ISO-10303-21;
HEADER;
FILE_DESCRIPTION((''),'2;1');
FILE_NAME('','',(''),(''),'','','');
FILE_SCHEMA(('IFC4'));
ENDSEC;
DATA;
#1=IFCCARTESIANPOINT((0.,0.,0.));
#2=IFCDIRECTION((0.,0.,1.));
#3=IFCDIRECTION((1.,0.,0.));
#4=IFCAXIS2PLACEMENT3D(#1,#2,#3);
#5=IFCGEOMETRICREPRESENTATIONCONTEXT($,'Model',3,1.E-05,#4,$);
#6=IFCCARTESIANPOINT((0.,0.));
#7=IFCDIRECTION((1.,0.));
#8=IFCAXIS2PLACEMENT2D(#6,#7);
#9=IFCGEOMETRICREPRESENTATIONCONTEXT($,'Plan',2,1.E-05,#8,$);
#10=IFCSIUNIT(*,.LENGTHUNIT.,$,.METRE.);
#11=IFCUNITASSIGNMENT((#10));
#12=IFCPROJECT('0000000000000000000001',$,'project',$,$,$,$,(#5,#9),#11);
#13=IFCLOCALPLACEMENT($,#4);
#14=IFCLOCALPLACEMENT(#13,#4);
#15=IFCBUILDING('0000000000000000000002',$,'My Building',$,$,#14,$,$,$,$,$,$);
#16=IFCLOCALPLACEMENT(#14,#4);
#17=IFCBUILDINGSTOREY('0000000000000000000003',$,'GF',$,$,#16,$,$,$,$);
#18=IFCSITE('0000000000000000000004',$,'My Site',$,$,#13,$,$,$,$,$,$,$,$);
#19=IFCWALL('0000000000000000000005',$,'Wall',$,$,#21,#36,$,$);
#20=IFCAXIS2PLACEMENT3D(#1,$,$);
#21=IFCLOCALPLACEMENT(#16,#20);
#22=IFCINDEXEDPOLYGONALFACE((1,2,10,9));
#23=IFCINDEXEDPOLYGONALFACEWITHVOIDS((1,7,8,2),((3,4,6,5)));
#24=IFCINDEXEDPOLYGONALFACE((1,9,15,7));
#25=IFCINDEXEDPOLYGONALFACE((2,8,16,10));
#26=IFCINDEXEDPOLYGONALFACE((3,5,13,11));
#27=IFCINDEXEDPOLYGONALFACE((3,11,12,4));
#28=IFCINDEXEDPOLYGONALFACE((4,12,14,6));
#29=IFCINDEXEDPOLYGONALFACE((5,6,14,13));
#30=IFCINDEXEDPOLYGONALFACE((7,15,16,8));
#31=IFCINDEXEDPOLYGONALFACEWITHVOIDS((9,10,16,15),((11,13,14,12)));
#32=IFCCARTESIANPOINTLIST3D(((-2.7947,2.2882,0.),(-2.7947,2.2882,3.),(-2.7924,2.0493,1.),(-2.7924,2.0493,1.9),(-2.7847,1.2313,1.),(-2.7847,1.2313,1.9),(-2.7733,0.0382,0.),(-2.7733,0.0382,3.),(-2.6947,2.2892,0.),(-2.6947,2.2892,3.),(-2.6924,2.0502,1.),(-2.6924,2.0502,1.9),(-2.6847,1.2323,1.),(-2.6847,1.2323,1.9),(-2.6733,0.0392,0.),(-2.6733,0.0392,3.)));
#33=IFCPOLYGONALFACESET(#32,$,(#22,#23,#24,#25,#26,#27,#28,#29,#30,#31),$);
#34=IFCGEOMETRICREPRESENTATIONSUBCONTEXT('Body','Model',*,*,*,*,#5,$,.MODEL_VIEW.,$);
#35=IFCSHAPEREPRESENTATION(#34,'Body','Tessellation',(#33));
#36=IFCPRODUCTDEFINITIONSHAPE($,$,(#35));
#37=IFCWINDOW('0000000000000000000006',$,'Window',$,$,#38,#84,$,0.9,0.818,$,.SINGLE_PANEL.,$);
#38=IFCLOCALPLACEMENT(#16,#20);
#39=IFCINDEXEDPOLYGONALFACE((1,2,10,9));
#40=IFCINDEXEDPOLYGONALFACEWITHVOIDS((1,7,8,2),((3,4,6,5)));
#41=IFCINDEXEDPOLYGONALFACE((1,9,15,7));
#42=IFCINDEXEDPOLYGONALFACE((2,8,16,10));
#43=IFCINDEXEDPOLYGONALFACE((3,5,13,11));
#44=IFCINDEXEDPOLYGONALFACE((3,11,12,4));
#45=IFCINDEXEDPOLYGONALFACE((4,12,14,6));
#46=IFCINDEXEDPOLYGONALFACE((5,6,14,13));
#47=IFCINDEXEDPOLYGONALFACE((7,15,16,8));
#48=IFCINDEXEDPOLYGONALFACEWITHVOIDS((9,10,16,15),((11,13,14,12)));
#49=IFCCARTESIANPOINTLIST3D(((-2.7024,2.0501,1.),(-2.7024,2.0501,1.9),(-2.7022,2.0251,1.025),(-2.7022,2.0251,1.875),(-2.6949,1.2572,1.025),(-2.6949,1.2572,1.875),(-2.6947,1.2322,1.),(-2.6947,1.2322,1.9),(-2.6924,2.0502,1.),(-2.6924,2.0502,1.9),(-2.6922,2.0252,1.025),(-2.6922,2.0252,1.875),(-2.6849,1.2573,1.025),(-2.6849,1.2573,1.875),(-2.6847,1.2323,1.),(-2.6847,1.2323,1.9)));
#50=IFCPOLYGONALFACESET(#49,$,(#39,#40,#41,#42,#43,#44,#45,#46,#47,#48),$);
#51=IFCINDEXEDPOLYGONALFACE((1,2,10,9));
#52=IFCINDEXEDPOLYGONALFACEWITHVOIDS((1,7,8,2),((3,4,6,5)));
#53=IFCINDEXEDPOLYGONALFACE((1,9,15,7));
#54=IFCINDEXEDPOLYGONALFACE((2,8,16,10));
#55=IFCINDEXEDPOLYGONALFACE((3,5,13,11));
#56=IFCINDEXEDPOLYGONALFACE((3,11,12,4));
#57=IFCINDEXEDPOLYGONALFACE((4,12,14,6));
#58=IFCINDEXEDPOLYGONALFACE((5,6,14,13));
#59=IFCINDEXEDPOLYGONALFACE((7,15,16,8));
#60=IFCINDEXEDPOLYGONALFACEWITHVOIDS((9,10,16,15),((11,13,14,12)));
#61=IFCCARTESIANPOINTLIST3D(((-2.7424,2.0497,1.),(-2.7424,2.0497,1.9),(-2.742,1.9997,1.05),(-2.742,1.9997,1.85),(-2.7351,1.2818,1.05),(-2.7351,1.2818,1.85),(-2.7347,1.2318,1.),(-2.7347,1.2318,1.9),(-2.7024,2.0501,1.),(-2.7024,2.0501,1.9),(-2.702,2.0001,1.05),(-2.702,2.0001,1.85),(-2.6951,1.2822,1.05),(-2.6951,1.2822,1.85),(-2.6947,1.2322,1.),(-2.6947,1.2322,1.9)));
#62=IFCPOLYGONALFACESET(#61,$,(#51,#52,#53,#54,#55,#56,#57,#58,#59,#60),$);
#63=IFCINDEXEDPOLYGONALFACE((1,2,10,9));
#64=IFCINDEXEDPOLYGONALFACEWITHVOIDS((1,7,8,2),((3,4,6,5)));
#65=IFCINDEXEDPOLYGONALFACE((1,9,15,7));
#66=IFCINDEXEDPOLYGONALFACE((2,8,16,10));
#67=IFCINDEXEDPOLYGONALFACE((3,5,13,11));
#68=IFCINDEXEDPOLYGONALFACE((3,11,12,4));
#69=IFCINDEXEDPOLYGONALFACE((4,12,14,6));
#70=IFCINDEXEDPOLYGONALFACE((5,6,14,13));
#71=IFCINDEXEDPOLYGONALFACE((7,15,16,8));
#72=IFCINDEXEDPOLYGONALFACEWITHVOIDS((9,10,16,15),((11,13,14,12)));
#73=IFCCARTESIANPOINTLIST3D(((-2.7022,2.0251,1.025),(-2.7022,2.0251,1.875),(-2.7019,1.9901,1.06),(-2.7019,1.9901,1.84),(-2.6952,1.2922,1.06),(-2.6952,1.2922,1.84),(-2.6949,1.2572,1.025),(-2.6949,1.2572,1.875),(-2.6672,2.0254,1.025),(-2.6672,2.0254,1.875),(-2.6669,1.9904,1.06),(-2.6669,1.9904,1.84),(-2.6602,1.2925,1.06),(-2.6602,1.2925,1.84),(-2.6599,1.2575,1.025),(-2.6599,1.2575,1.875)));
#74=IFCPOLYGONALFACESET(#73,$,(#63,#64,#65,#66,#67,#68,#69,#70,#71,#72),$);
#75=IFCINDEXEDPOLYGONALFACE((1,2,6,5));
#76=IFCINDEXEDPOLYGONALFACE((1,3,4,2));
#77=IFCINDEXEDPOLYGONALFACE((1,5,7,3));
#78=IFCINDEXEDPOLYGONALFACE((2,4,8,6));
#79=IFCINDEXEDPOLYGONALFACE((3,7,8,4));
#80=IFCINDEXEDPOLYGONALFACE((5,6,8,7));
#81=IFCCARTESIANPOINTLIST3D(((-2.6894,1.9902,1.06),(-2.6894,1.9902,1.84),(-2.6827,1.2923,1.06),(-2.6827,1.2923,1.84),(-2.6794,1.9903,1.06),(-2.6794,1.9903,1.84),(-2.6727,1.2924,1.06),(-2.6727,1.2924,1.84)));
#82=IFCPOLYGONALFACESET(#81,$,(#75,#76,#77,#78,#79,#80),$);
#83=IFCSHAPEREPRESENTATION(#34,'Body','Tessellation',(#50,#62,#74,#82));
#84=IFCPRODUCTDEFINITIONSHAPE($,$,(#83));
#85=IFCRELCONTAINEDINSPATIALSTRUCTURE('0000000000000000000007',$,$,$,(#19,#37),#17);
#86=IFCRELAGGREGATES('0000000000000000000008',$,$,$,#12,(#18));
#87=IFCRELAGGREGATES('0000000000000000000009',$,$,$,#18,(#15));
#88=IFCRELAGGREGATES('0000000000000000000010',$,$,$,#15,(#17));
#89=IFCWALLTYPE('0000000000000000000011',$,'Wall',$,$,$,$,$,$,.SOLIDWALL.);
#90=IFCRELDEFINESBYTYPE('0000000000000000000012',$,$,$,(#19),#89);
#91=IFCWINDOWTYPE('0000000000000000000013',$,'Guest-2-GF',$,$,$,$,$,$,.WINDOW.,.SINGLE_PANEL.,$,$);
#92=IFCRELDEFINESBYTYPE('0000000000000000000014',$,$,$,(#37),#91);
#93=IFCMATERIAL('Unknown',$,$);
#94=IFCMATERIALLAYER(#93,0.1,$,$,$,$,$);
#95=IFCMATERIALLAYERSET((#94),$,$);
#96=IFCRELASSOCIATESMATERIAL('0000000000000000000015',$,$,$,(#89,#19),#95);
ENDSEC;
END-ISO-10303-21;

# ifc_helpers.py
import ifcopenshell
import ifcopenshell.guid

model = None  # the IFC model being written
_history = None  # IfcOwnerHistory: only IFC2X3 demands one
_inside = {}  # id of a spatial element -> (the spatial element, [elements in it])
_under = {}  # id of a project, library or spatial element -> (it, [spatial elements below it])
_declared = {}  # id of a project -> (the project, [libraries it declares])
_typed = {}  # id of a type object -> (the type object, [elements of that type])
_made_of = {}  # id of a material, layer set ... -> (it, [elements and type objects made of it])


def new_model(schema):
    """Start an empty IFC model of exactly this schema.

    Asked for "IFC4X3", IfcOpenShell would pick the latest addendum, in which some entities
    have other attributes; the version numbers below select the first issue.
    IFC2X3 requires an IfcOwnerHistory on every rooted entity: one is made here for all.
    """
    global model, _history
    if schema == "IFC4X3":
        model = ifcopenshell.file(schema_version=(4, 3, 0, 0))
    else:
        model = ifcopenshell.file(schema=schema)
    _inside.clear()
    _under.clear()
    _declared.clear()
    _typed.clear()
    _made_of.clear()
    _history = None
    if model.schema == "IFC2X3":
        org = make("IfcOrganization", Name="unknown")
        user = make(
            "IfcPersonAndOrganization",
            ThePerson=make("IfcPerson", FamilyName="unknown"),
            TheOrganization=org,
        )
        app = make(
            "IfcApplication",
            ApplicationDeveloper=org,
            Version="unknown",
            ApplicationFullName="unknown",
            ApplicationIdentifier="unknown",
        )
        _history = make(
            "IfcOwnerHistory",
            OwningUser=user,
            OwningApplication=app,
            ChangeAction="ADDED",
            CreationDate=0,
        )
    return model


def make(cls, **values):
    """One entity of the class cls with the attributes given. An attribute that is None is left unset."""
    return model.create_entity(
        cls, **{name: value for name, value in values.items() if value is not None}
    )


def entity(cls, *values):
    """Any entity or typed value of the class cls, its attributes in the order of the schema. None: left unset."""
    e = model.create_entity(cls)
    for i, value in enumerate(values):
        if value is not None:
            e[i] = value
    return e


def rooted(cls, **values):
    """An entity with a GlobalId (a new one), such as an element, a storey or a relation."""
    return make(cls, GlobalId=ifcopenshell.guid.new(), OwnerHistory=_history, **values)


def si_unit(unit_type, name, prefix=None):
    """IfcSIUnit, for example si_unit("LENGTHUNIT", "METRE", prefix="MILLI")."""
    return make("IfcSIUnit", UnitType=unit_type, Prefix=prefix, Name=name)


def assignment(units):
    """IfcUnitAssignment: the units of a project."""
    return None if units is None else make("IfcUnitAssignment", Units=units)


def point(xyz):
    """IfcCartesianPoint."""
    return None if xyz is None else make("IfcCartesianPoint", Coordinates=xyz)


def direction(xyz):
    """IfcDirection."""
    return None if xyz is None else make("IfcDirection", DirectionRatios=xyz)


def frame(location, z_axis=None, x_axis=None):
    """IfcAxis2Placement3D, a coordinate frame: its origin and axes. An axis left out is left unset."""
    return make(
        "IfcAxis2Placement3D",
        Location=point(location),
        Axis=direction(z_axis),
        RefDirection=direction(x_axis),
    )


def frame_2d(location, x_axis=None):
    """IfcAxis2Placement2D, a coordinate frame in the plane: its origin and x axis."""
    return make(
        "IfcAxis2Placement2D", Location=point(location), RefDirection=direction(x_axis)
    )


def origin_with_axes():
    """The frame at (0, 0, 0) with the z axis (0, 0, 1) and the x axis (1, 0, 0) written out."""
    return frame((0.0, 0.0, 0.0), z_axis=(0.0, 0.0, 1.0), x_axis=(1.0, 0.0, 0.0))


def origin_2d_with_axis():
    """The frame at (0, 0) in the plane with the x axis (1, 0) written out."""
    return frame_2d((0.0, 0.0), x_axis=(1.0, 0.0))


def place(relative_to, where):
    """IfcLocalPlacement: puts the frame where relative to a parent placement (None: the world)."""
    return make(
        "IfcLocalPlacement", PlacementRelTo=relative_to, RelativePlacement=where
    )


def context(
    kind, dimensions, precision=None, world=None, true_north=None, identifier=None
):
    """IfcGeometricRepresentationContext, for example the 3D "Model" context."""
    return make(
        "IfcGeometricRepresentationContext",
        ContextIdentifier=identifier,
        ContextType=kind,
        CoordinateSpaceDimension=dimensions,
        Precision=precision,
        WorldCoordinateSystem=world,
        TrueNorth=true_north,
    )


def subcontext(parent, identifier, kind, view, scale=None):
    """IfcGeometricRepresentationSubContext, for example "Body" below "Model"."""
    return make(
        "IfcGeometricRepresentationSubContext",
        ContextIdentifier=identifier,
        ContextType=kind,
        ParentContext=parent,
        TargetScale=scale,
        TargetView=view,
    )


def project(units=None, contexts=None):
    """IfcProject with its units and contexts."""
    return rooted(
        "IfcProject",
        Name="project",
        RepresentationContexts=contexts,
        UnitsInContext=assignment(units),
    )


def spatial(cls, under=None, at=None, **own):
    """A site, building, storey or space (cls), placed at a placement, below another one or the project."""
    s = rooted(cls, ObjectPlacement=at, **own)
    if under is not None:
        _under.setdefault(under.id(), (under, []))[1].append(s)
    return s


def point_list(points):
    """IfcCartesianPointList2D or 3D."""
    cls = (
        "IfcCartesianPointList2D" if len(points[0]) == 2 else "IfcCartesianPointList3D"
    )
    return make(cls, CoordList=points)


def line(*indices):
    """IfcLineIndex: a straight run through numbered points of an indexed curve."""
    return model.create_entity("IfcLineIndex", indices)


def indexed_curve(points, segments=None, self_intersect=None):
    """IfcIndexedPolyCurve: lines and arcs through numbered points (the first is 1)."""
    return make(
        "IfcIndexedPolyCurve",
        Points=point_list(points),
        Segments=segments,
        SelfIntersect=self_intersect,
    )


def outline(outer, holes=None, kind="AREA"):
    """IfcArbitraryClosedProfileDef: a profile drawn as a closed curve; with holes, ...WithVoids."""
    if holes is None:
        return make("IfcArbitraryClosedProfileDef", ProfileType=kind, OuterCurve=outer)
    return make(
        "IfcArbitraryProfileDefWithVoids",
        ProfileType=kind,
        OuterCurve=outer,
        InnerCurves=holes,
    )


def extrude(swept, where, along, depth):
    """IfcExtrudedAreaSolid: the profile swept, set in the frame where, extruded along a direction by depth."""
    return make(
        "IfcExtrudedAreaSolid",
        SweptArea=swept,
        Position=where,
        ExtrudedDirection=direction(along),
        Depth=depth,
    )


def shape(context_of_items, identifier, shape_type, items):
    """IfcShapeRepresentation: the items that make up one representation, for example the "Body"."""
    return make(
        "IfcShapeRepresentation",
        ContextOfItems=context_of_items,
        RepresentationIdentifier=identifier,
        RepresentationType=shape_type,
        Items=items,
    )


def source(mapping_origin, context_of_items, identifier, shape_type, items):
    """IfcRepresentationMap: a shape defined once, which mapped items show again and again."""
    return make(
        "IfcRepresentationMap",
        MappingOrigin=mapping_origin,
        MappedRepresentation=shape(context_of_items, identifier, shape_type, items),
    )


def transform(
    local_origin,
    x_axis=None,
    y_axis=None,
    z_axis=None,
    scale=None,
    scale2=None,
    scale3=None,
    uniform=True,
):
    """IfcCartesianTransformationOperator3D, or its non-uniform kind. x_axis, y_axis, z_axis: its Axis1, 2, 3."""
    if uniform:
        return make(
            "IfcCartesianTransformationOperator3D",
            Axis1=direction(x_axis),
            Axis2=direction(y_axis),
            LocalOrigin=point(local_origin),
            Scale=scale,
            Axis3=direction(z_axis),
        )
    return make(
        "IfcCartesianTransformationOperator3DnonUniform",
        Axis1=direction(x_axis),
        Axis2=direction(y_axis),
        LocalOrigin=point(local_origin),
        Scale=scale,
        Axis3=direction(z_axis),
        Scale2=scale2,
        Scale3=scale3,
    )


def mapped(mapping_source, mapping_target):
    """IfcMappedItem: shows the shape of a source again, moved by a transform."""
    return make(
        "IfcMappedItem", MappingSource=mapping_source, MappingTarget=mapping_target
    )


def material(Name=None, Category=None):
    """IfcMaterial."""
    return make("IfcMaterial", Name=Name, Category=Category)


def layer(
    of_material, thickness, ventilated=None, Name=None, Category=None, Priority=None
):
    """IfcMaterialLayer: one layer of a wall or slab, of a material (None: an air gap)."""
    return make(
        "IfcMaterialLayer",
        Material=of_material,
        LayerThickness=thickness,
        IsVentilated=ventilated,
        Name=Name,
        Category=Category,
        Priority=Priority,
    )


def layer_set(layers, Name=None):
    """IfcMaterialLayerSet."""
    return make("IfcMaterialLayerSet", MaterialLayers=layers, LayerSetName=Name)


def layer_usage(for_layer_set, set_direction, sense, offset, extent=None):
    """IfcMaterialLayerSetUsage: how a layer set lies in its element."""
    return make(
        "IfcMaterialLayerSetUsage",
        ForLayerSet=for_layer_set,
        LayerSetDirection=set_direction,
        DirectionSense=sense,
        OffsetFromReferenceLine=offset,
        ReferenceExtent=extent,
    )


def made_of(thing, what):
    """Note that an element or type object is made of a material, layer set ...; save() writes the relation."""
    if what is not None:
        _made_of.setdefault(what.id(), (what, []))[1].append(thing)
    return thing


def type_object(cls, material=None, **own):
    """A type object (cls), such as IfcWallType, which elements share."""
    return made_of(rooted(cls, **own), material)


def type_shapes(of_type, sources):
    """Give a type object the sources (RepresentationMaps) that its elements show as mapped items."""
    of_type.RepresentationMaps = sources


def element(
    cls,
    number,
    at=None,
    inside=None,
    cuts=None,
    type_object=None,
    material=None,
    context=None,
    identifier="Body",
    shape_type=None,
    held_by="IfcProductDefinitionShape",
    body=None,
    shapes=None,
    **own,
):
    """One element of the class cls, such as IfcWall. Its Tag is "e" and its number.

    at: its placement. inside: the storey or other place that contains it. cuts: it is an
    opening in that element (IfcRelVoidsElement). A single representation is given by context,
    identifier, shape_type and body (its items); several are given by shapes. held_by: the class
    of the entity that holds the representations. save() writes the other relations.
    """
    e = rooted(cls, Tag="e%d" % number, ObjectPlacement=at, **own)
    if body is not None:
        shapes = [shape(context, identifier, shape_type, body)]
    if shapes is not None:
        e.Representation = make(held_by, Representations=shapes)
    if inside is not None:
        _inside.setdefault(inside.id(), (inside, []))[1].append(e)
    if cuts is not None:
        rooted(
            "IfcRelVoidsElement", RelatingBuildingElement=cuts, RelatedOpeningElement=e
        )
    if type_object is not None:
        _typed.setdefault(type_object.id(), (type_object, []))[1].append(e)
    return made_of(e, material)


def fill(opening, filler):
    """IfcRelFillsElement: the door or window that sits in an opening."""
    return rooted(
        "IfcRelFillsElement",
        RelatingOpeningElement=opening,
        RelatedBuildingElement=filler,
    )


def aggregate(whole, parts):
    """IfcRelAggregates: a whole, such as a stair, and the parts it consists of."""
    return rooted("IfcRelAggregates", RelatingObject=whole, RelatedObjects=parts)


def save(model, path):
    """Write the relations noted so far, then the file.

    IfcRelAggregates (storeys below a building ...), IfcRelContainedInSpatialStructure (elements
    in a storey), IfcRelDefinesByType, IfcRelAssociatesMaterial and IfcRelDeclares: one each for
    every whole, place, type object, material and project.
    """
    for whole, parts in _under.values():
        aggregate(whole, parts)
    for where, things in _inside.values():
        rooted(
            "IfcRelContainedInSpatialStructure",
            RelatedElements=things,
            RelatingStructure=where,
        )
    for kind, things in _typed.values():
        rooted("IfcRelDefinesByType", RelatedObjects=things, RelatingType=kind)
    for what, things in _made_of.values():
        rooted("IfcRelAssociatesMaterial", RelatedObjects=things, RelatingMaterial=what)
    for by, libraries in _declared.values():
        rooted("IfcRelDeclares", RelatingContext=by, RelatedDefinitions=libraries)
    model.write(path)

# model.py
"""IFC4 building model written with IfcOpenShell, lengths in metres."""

from ifc_helpers import new_model, entity, si_unit, frame, origin_with_axes, origin_2d_with_axis, place, context, subcontext, project, spatial, line, indexed_curve, outline, extrude, shape, source, transform, mapped, material, layer, layer_set, layer_usage, type_object, type_shapes, element, fill, save


model = new_model("IFC4")

# Units and contexts
model_context = context("Model", 3, precision=1e-05, world=origin_with_axes())
plan_context = context("Plan", 2, precision=1e-05, world=origin_2d_with_axis())
body_context_1 = subcontext(model_context, "Body", "Model", "MODEL_VIEW")
body_context_2 = subcontext(plan_context, "Body", "Plan", "PLAN_VIEW")
ifc_project = project(units=[si_unit("LENGTHUNIT", "METRE")], contexts=[model_context, plan_context])

# Site, building, storey
site_placement = place(None, origin_with_axes())
site = spatial("IfcSite", under=ifc_project, at=site_placement, Name="My Site")
building_placement = place(site_placement, origin_with_axes())
building = spatial("IfcBuilding", under=site, at=building_placement, Name="My Building")
storey_placement = place(building_placement, origin_with_axes())
storey = spatial("IfcBuildingStorey", under=building, at=storey_placement, Name="GF")

# Shared definitions
ifc_material = material(Name="Unknown")

# Shared definitions
ifc_layer_1 = layer(ifc_material, 0.1)
ifc_layer_set_1 = layer_set([ifc_layer_1])
wall_type = type_object("IfcWallType", Name="Wall", PredefinedType="SOLIDWALL", material=ifc_layer_set_1)

# Wall, opening, window
ifc_layer_usage_1 = layer_usage(ifc_layer_set_1, "AXIS2", "POSITIVE", 0.0)
wall_1_placement = place(storey_placement, frame((-2.7947, 2.2882, 0.0), z_axis=(0.0, 0.0, 1.0), x_axis=(0.009494, -0.999955, 0.0)))
wall_1 = element("IfcWall", 1, at=wall_1_placement, inside=storey, type_object=wall_type, material=ifc_layer_usage_1, Name="Wall", context=body_context_1, shape_type="SweptSolid", body=[
    extrude(outline(indexed_curve([(0.0, 0.0), (0.0, 0.1), (2.2501, 0.1), (2.2501, 0.0)], segments=[line(1, 2, 3, 4, 1)])), origin_with_axes(), (0.0, 0.0, 1.0), 3.0),
])
shared_shape_1 = source(origin_with_axes(), body_context_1, "Body", "SweptSolid", [
    extrude(outline(indexed_curve([(0.0, 0.0), (0.818, 0.0), (0.818, 0.9), (0.0, 0.9)], segments=[line(1, 2, 3, 4, 1)])), frame((0.0, -0.6, 0.0), z_axis=(0.0, -1.0, 0.0), x_axis=(1.0, 0.0, 0.0)), (0.0, 0.0, -1.0), 1.2),
])
opening_1_placement = place(wall_1_placement, frame((0.239, 0.0, 1.0), z_axis=(0.0, 0.0, 1.0), x_axis=(1.0, 0.0, 0.0)))
opening_1 = element("IfcOpeningElement", 2, at=opening_1_placement, cuts=wall_1, PredefinedType="OPENING", context=body_context_1, shape_type="MappedRepresentation", body=[
    mapped(shared_shape_1, transform((0.0, 0.0, 0.0), x_axis=(1.0, 0.0, 0.0), y_axis=(0.0, 1.0, 0.0), z_axis=(0.0, 0.0, 1.0), scale=1.0)),
])
window_type_1 = type_object("IfcWindowType", Name="Guest-2-GF", PartitioningType="SINGLE_PANEL", PredefinedType="WINDOW")
shared_shape_2 = source(origin_with_axes(), body_context_1, "Body", "SweptSolid", [
    extrude(outline(indexed_curve([(0.0, 0.0), (0.818, 0.0), (0.818, 0.9), (0.0, 0.9)], segments=[line(1, 2, 3, 4, 1)]), holes=[indexed_curve([(0.025, 0.025), (0.793, 0.025), (0.793, 0.875), (0.025, 0.875)], segments=[line(1, 2, 3, 4, 1)])]), frame((0.0, 0.09, 0.0), z_axis=(0.0, -1.0, 0.0), x_axis=(1.0, 0.0, 0.0)), (0.0, 0.0, -1.0), 0.01),
    extrude(outline(indexed_curve([(0.0, 0.0), (0.818, 0.0), (0.818, 0.9), (0.0, 0.9)], segments=[line(1, 2, 3, 4, 1)]), holes=[indexed_curve([(0.05, 0.05), (0.768, 0.05), (0.768, 0.85), (0.05, 0.85)], segments=[line(1, 2, 3, 4, 1)])]), frame((0.0, 0.05, 0.0), z_axis=(0.0, -1.0, 0.0), x_axis=(1.0, 0.0, 0.0)), (0.0, 0.0, -1.0), 0.04),
    extrude(outline(indexed_curve([(0.0, 0.0), (0.768, 0.0), (0.768, 0.85), (0.0, 0.85)], segments=[line(1, 2, 3, 4, 1)]), holes=[indexed_curve([(0.035, 0.035), (0.733, 0.035), (0.733, 0.815), (0.035, 0.815)], segments=[line(1, 2, 3, 4, 1)])]), frame((0.025, 0.09, 0.025), z_axis=(0.0, -1.0, 0.0), x_axis=(1.0, 0.0, 0.0)), (0.0, 0.0, -1.0), 0.035),
    extrude(outline(indexed_curve([(0.035, 0.035), (0.733, 0.035), (0.733, 0.815), (0.035, 0.815)], segments=[line(1, 2, 3, 4, 1)])), frame((0.025, 0.1025, 0.025), z_axis=(0.0, -1.0, 0.0), x_axis=(1.0, 0.0, 0.0)), (0.0, 0.0, -1.0), 0.01),
])
shared_shape_3 = source(origin_with_axes(), body_context_2, "Body", "Curve2D", [
    entity("IfcIndexedPolyCurve", entity("IfcCartesianPointList2D", [[0.05, 0.05], [0.768, 0.05]])),
    entity("IfcIndexedPolyCurve", entity("IfcCartesianPointList2D", [[0.0, 0.1], [0.025, 0.1], [0.025, 0.09], [0.05, 0.09], [0.05, 0.05], [0.0, 0.05]]), [entity("IfcLineIndex", [1, 2, 3, 4, 5, 6, 1])]),
    entity("IfcIndexedPolyCurve", entity("IfcCartesianPointList2D", [[0.818, 0.1], [0.793, 0.1], [0.793, 0.09], [0.768, 0.09], [0.768, 0.05], [0.818, 0.05]]), [entity("IfcLineIndex", [1, 2, 3, 4, 5, 6, 1])]),
    entity("IfcIndexedPolyCurve", entity("IfcCartesianPointList2D", [[0.025, 0.09], [0.06, 0.09], [0.06, 0.125], [0.025, 0.125]]), [entity("IfcLineIndex", [1, 2, 3, 4, 1])]),
    entity("IfcIndexedPolyCurve", entity("IfcCartesianPointList2D", [[0.793, 0.09], [0.758, 0.09], [0.758, 0.125], [0.793, 0.125]]), [entity("IfcLineIndex", [1, 2, 3, 4, 1])]),
    entity("IfcIndexedPolyCurve", entity("IfcCartesianPointList2D", [[0.06, 0.09], [0.758, 0.09]])),
    entity("IfcIndexedPolyCurve", entity("IfcCartesianPointList2D", [[0.06, 0.125], [0.758, 0.125]])),
    entity("IfcIndexedPolyCurve", entity("IfcCartesianPointList2D", [[0.06, 0.1075], [0.758, 0.1075]])),
])
type_shapes(window_type_1, [shared_shape_2, shared_shape_3])
window_1_placement = place(opening_1_placement, frame((0.0, 0.0, 0.0), z_axis=(0.0, 0.0, 1.0), x_axis=(1.0, 0.0, 0.0)))
window_1 = element("IfcWindow", 3, at=window_1_placement, inside=storey, type_object=window_type_1, Name="Window", OverallHeight=0.9, OverallWidth=0.818, PartitioningType="SINGLE_PANEL", shapes=[
    shape(body_context_1, "Body", "MappedRepresentation", [mapped(shared_shape_2, transform((0.0, 0.0, 0.0), x_axis=(1.0, 0.0, 0.0), y_axis=(0.0, 1.0, 0.0), z_axis=(0.0, 0.0, 1.0), scale=1.0))]),
    shape(body_context_2, "Body", "MappedRepresentation", [mapped(shared_shape_3, transform((0.0, 0.0, 0.0), x_axis=(1.0, 0.0, 0.0), y_axis=(0.0, 1.0, 0.0), z_axis=(0.0, 0.0, 1.0), scale=1.0))]),
])
fill(opening_1, window_1)

save(model, "model.ifc")
